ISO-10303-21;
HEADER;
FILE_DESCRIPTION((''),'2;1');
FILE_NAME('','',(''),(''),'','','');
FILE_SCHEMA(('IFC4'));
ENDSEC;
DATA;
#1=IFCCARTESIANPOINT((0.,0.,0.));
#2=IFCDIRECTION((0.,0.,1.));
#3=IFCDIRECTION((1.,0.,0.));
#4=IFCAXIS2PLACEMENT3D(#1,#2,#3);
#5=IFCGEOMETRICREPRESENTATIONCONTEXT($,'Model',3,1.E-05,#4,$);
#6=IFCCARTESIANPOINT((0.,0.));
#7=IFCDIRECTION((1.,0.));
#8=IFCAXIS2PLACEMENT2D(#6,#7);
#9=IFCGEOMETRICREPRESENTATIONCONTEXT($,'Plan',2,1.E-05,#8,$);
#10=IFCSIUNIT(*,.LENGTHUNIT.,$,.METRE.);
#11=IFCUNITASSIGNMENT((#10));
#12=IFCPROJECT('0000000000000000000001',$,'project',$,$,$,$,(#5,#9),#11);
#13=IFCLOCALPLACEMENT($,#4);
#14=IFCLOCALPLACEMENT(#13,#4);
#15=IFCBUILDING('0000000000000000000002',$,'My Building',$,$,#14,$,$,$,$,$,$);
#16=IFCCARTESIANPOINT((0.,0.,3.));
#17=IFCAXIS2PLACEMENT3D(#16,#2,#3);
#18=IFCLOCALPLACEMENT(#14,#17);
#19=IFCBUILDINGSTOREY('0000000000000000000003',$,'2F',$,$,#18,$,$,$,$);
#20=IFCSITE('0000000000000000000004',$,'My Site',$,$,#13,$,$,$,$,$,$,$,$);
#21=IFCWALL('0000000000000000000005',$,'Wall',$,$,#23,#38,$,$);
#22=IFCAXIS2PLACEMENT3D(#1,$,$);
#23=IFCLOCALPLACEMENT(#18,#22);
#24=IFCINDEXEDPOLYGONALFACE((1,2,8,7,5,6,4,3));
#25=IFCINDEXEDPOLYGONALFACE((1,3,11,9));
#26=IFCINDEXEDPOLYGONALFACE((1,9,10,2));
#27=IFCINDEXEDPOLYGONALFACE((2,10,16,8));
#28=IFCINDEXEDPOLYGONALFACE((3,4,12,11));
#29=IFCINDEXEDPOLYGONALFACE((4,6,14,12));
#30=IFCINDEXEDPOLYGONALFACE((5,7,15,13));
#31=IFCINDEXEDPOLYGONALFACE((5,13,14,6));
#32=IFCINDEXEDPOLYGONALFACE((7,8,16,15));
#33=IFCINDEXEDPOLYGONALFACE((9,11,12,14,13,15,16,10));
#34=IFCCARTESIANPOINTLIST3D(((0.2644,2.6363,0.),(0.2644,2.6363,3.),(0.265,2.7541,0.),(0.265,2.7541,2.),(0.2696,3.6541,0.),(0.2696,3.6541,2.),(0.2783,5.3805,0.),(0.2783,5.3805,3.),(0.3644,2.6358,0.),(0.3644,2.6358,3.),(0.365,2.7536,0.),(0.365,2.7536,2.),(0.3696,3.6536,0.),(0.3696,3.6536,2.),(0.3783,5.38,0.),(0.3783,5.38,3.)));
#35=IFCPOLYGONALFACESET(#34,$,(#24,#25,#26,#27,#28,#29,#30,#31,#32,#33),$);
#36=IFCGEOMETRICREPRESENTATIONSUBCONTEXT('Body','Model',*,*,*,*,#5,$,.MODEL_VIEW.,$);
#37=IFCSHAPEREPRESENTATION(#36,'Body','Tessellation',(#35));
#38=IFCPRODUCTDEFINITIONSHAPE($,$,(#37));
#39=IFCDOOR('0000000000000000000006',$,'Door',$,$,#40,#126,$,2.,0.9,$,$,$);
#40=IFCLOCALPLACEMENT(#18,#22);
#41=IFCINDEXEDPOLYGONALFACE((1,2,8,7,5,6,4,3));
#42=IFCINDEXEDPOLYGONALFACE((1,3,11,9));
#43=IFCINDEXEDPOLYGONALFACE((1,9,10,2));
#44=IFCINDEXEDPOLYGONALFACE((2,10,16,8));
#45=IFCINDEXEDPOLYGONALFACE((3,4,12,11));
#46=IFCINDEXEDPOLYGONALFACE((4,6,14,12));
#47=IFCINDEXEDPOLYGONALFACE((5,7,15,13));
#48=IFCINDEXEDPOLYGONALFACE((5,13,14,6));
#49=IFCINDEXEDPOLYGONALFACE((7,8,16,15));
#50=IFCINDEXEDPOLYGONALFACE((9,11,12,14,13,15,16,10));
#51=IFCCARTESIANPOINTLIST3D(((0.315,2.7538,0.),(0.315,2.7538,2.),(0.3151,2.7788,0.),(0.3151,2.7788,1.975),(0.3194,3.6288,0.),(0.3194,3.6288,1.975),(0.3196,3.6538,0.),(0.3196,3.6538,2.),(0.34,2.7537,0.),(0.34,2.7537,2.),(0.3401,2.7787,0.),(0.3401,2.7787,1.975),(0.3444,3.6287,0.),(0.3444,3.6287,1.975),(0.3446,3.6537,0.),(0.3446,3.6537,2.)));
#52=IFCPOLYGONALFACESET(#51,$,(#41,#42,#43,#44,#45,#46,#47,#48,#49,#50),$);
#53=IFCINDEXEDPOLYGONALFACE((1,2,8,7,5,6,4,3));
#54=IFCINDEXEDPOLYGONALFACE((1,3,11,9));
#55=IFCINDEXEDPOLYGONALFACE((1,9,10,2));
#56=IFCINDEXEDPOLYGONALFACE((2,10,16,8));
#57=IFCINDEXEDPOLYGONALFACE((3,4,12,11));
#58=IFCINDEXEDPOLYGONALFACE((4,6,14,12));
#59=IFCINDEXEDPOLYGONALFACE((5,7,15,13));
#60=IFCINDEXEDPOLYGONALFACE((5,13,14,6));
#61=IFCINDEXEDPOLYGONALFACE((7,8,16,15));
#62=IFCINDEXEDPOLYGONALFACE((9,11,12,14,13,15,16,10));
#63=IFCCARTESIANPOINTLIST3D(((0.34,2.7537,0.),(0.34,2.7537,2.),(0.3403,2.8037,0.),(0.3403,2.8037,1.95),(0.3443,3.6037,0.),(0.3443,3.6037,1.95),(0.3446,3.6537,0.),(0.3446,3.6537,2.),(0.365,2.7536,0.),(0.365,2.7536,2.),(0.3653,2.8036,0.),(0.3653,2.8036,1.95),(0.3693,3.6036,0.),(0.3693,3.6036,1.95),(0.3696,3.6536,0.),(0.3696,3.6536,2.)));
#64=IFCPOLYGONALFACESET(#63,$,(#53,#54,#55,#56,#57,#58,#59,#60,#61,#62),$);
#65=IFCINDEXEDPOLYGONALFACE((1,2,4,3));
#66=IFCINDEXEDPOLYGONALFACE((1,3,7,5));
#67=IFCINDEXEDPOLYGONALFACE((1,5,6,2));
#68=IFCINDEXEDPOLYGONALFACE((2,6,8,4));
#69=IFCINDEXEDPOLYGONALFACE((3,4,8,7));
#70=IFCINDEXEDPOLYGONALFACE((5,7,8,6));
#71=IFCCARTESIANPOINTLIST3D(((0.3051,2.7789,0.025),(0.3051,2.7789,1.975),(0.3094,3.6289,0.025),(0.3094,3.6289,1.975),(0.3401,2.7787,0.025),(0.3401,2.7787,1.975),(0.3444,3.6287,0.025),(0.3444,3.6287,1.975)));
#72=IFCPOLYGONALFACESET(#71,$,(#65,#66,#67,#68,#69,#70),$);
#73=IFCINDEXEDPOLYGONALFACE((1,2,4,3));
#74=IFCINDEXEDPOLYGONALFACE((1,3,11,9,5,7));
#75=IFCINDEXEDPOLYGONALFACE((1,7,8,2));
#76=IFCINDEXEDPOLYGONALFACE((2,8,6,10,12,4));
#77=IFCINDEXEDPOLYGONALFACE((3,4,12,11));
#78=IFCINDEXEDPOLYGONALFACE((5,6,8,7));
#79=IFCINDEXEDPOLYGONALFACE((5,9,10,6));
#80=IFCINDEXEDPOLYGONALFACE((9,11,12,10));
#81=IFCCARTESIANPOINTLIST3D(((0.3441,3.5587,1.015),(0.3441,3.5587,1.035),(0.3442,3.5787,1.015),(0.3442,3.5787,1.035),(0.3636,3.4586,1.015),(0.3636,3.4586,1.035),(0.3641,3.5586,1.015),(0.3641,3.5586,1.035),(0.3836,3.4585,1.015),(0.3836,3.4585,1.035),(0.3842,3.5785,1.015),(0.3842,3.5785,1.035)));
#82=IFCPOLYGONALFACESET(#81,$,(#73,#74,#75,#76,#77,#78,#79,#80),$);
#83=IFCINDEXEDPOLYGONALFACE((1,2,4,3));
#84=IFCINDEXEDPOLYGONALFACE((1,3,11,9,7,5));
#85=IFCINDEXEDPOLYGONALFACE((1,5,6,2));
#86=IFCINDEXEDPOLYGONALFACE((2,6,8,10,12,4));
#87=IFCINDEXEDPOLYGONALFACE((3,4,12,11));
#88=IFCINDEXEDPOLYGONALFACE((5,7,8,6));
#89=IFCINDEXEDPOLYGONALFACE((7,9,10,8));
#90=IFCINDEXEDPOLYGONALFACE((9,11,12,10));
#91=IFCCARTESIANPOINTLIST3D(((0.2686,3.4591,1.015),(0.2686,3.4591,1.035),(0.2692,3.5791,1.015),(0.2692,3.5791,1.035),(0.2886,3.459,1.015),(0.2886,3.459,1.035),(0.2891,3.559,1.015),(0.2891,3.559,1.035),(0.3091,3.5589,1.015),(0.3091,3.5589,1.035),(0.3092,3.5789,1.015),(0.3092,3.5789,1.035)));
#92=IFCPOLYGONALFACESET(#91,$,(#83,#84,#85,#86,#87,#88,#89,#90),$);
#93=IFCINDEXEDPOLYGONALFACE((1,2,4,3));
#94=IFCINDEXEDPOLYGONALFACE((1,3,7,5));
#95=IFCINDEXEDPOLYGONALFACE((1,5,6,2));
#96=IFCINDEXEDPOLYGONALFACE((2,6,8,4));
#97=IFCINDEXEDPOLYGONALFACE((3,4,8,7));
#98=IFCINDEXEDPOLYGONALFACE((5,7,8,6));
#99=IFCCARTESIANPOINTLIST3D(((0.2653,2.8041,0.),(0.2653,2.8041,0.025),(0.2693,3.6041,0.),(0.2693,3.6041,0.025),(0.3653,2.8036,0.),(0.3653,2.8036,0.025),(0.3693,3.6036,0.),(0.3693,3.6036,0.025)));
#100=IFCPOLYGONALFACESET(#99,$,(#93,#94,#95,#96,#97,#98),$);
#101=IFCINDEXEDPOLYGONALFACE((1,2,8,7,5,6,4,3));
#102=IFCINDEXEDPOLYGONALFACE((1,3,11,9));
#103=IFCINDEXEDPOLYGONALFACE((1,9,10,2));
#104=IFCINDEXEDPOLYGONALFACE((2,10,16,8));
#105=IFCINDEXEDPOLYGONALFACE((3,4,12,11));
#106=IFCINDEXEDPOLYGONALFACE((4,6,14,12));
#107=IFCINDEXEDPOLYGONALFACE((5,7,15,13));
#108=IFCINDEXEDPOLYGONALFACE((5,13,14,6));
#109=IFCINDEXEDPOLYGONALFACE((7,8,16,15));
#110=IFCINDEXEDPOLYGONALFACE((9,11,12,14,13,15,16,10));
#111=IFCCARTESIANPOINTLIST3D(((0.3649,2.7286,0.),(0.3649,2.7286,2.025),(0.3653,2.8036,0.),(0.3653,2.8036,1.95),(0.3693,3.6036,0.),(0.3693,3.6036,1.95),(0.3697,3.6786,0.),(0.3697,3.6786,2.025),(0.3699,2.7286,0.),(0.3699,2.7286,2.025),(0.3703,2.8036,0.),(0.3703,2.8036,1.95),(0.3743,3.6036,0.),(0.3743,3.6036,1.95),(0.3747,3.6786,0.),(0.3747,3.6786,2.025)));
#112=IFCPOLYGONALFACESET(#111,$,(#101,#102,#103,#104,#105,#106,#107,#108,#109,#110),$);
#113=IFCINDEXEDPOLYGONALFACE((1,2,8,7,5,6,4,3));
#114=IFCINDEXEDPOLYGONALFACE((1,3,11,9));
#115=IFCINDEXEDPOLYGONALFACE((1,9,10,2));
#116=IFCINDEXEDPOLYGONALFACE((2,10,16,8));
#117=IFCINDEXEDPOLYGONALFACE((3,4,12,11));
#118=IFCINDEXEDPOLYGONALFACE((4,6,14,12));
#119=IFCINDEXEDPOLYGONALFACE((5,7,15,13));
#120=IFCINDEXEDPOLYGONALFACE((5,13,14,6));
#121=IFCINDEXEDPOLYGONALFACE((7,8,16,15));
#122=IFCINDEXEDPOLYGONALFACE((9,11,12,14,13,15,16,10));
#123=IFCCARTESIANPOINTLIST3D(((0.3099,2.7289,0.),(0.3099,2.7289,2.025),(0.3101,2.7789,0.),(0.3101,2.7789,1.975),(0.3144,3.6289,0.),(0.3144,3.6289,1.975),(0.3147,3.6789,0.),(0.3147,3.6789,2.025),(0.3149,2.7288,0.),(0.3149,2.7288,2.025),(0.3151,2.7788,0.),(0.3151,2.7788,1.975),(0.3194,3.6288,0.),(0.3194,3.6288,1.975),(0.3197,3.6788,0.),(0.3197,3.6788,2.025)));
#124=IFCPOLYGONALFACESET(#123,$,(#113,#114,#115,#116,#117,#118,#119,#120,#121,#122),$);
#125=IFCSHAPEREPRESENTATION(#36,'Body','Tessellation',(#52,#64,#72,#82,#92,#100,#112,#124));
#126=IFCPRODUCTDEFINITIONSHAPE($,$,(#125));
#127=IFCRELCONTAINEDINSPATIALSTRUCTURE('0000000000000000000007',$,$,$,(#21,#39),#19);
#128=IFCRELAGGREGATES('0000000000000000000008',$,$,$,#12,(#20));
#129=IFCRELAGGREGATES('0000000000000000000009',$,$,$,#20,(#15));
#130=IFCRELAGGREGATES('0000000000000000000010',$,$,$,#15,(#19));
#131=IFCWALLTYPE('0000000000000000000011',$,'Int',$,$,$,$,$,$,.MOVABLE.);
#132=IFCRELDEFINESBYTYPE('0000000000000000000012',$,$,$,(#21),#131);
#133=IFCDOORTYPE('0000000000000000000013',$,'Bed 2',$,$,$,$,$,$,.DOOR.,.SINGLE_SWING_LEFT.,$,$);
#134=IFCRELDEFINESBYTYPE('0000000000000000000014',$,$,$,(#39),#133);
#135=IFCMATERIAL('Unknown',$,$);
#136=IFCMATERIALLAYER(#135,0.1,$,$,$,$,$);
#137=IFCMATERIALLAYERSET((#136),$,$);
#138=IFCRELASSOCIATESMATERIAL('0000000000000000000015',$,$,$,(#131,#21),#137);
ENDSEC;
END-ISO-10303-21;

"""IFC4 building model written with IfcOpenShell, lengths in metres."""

from ifc_helpers import new_model, entity, si_unit, frame, origin_with_axes, origin_2d_with_axis, place, context, subcontext, project, spatial, line, indexed_curve, outline, extrude, shape, source, transform, mapped, material, layer, layer_set, layer_usage, type_object, type_shapes, element, fill, save


model = new_model("IFC4")

# Units and contexts
model_context = context("Model", 3, precision=1e-05, world=origin_with_axes())
plan_context = context("Plan", 2, precision=1e-05, world=origin_2d_with_axis())
body_context_1 = subcontext(model_context, "Body", "Model", "MODEL_VIEW")
body_context_2 = subcontext(plan_context, "Body", "Plan", "PLAN_VIEW")
ifc_project = project(units=[si_unit("LENGTHUNIT", "METRE")], contexts=[model_context, plan_context])

# Site, building, storey
site_placement = place(None, origin_with_axes())
site = spatial("IfcSite", under=ifc_project, at=site_placement, Name="My Site")
building_placement = place(site_placement, origin_with_axes())
building = spatial("IfcBuilding", under=site, at=building_placement, Name="My Building")
storey_placement = place(building_placement, frame((0.0, 0.0, 3.0), z_axis=(0.0, 0.0, 1.0), x_axis=(1.0, 0.0, 0.0)))
storey = spatial("IfcBuildingStorey", under=building, at=storey_placement, Name="2F")

# Shared definitions
ifc_material = material(Name="Unknown")

# Shared definitions
ifc_layer_1 = layer(ifc_material, 0.1)
ifc_layer_set_1 = layer_set([ifc_layer_1])
wall_type_1 = type_object("IfcWallType", Name="Int", PredefinedType="MOVABLE", material=ifc_layer_set_1)

# Wall, opening, door
ifc_layer_usage_1 = layer_usage(ifc_layer_set_1, "AXIS2", "POSITIVE", 0.0)
wall_1_placement = place(storey_placement, frame((0.3644, 2.6358, 0.0), z_axis=(0.0, 0.0, 1.0), x_axis=(0.005081, 0.999987, 0.0)))
wall_1 = element("IfcWall", 1, at=wall_1_placement, inside=storey, type_object=wall_type_1, material=ifc_layer_usage_1, Name="Wall", context=body_context_1, shape_type="SweptSolid", body=[
    extrude(outline(indexed_curve([(0.0, 0.0), (0.0, 0.1), (2.7442, 0.1), (2.7442, 0.0)], segments=[line(1, 2, 3, 4, 1)])), origin_with_axes(), (0.0, 0.0, 1.0), 3.0),
])
shared_shape_1 = source(origin_with_axes(), body_context_1, "Body", "SweptSolid", [
    extrude(outline(indexed_curve([(0.0, 0.0), (0.9, 0.0), (0.9, 2.0), (0.0, 2.0)], segments=[line(1, 2, 3, 4, 1)])), frame((0.0, -0.6, 0.0), z_axis=(0.0, -1.0, 0.0), x_axis=(1.0, 0.0, 0.0)), (0.0, 0.0, -1.0), 1.2),
])
opening_1_placement = place(wall_1_placement, frame((0.1178, 0.0, 0.0), z_axis=(0.0, 0.0, 1.0), x_axis=(1.0, 0.000001, 0.0)))
opening_1 = element("IfcOpeningElement", 2, at=opening_1_placement, cuts=wall_1, PredefinedType="OPENING", context=body_context_1, shape_type="MappedRepresentation", body=[
    mapped(shared_shape_1, transform((0.0, 0.0, 0.0), x_axis=(1.0, 0.0, 0.0), y_axis=(0.0, 1.0, 0.0), z_axis=(0.0, 0.0, 1.0), scale=1.0)),
])
door_type_1 = type_object("IfcDoorType", Name="Bed 2", OperationType="SINGLE_SWING_LEFT", PredefinedType="DOOR")
shared_shape_2 = source(origin_with_axes(), body_context_1, "Body", "SweptSolid", [
    extrude(outline(indexed_curve([(0.0, 0.0), (0.0, 2.0), (0.9, 2.0), (0.9, 0.0), (0.875, 0.0), (0.875, 1.975), (0.025, 1.975), (0.025, 0.0)], segments=[line(1, 2, 3, 4, 5, 6, 7, 8, 1)])), frame((0.0, 0.025, 0.0), z_axis=(0.0, -1.0, 0.0), x_axis=(1.0, 0.0, 0.0)), (0.0, 0.0, -1.0), 0.025),
    extrude(outline(indexed_curve([(0.0, 0.0), (0.0, 2.0), (0.9, 2.0), (0.9, 0.0), (0.85, 0.0), (0.85, 1.95), (0.05, 1.95), (0.05, 0.0)], segments=[line(1, 2, 3, 4, 5, 6, 7, 8, 1)])), frame((0.0, 0.0, 0.0), z_axis=(0.0, -1.0, 0.0), x_axis=(1.0, 0.0, 0.0)), (0.0, 0.0, -1.0), 0.025),
    extrude(outline(indexed_curve([(0.0, 0.0), (0.85, 0.0), (0.85, 0.035), (0.0, 0.035)], segments=[line(1, 2, 3, 4, 1)])), frame((0.025, 0.025, 0.025), z_axis=(0.0, 0.0, 1.0), x_axis=(1.0, 0.0, 0.0)), (0.0, 0.0, 1.0), 1.95),
    extrude(outline(indexed_curve([(-0.02, 0.0), (-0.02, -0.02), (-0.12, -0.02), (-0.12, -0.04), (0.0, -0.04), (0.0, 0.0), (-0.02, 0.0)])), frame((0.825, 0.025, 1.015), z_axis=(0.0, 0.0, 1.0), x_axis=(1.0, 0.0, 0.0)), (0.0, 0.0, 1.0), 0.02),
    extrude(outline(indexed_curve([(0.0, 0.0), (0.0, 0.04), (-0.12, 0.04), (-0.12, 0.02), (-0.02, 0.02), (-0.02, 0.0)], segments=[line(1, 2, 3, 4, 5, 6, 1)])), frame((0.825, 0.06, 1.015), z_axis=(0.0, 0.0, 1.0), x_axis=(1.0, 0.0, 0.0)), (0.0, 0.0, 1.0), 0.02),
    extrude(outline(indexed_curve([(0.0, 0.1), (0.8, 0.1), (0.8, 0.0), (0.0, 0.0), (0.0, 0.1)])), frame((0.05, 0.0, 0.0), z_axis=(0.0, 0.0, 1.0), x_axis=(1.0, 0.0, 0.0)), (0.0, 0.0, 1.0), 0.025),
    extrude(outline(indexed_curve([(0.075, 0.0), (0.075, 1.95), (0.875, 1.95), (0.875, 0.0), (0.95, 0.0), (0.95, 2.025), (0.0, 2.025), (0.0, 0.0), (0.075, 0.0)])), frame((-0.025, -0.005, 0.0), z_axis=(0.0, -1.0, 0.0), x_axis=(1.0, 0.0, 0.0)), (0.0, 0.0, -1.0), 0.005),
    extrude(outline(indexed_curve([(0.0, 0.0), (0.0, 2.025), (0.95, 2.025), (0.95, 0.0), (0.9, 0.0), (0.9, 1.975), (0.05, 1.975), (0.05, 0.0)], segments=[line(1, 2, 3, 4, 5, 6, 7, 8, 1)])), frame((-0.025, 0.05, 0.0), z_axis=(0.0, -1.0, 0.0), x_axis=(1.0, 0.0, 0.0)), (0.0, 0.0, -1.0), 0.005),
])
shared_shape_3 = source(origin_with_axes(), body_context_2, "Body", "Curve2D", [
    entity("IfcIndexedPolyCurve", entity("IfcCartesianPointList2D", [[0.0, 0.0], [0.0, 0.05], [0.025, 0.05], [0.025, 0.025], [0.05, 0.025], [0.05, 0.0]]), [entity("IfcLineIndex", [1, 2, 3, 4, 5, 6, 1])]),
    entity("IfcIndexedPolyCurve", entity("IfcCartesianPointList2D", [[0.9, 0.0], [0.9, 0.05], [0.875, 0.05], [0.875, 0.025], [0.85, 0.025], [0.85, 0.0]]), [entity("IfcLineIndex", [1, 2, 3, 4, 5, 6, 1])]),
    entity("IfcTrimmedCurve", entity("IfcEllipse", entity("IfcAxis2Placement2D", entity("IfcCartesianPoint", [0.06, 0.05]), entity("IfcDirection", [1.0, 0.0])), 0.815, 0.85), [entity("IfcCartesianPoint", [0.875, 0.05])], [entity("IfcCartesianPoint", [0.06, 0.9])], True, "CARTESIAN"),
    entity("IfcIndexedPolyCurve", entity("IfcCartesianPointList2D", [[0.025, 0.05], [0.06, 0.05], [0.06, 0.9], [0.025, 0.9]]), [entity("IfcLineIndex", [1, 2, 3, 4, 1])]),
])
type_shapes(door_type_1, [shared_shape_2, shared_shape_3])
door_1_placement = place(opening_1_placement, frame((0.0, 0.0, 0.0), z_axis=(0.0, 0.0, 1.0), x_axis=(1.0, 0.0, 0.0)))
door_1 = element("IfcDoor", 3, at=door_1_placement, inside=storey, type_object=door_type_1, Name="Door", OverallHeight=2.0, OverallWidth=0.9, shapes=[
    shape(body_context_1, "Body", "MappedRepresentation", [mapped(shared_shape_2, transform((0.0, 0.0, 0.0), x_axis=(1.0, 0.0, 0.0), y_axis=(0.0, 1.0, 0.0), z_axis=(0.0, 0.0, 1.0), scale=1.0))]),
    shape(body_context_2, "Body", "MappedRepresentation", [mapped(shared_shape_3, transform((0.0, 0.0, 0.0), x_axis=(1.0, 0.0, 0.0), y_axis=(0.0, 1.0, 0.0), z_axis=(0.0, 0.0, 1.0), scale=1.0))]),
])
fill(opening_1, door_1)

save(model, "model.ifc")
